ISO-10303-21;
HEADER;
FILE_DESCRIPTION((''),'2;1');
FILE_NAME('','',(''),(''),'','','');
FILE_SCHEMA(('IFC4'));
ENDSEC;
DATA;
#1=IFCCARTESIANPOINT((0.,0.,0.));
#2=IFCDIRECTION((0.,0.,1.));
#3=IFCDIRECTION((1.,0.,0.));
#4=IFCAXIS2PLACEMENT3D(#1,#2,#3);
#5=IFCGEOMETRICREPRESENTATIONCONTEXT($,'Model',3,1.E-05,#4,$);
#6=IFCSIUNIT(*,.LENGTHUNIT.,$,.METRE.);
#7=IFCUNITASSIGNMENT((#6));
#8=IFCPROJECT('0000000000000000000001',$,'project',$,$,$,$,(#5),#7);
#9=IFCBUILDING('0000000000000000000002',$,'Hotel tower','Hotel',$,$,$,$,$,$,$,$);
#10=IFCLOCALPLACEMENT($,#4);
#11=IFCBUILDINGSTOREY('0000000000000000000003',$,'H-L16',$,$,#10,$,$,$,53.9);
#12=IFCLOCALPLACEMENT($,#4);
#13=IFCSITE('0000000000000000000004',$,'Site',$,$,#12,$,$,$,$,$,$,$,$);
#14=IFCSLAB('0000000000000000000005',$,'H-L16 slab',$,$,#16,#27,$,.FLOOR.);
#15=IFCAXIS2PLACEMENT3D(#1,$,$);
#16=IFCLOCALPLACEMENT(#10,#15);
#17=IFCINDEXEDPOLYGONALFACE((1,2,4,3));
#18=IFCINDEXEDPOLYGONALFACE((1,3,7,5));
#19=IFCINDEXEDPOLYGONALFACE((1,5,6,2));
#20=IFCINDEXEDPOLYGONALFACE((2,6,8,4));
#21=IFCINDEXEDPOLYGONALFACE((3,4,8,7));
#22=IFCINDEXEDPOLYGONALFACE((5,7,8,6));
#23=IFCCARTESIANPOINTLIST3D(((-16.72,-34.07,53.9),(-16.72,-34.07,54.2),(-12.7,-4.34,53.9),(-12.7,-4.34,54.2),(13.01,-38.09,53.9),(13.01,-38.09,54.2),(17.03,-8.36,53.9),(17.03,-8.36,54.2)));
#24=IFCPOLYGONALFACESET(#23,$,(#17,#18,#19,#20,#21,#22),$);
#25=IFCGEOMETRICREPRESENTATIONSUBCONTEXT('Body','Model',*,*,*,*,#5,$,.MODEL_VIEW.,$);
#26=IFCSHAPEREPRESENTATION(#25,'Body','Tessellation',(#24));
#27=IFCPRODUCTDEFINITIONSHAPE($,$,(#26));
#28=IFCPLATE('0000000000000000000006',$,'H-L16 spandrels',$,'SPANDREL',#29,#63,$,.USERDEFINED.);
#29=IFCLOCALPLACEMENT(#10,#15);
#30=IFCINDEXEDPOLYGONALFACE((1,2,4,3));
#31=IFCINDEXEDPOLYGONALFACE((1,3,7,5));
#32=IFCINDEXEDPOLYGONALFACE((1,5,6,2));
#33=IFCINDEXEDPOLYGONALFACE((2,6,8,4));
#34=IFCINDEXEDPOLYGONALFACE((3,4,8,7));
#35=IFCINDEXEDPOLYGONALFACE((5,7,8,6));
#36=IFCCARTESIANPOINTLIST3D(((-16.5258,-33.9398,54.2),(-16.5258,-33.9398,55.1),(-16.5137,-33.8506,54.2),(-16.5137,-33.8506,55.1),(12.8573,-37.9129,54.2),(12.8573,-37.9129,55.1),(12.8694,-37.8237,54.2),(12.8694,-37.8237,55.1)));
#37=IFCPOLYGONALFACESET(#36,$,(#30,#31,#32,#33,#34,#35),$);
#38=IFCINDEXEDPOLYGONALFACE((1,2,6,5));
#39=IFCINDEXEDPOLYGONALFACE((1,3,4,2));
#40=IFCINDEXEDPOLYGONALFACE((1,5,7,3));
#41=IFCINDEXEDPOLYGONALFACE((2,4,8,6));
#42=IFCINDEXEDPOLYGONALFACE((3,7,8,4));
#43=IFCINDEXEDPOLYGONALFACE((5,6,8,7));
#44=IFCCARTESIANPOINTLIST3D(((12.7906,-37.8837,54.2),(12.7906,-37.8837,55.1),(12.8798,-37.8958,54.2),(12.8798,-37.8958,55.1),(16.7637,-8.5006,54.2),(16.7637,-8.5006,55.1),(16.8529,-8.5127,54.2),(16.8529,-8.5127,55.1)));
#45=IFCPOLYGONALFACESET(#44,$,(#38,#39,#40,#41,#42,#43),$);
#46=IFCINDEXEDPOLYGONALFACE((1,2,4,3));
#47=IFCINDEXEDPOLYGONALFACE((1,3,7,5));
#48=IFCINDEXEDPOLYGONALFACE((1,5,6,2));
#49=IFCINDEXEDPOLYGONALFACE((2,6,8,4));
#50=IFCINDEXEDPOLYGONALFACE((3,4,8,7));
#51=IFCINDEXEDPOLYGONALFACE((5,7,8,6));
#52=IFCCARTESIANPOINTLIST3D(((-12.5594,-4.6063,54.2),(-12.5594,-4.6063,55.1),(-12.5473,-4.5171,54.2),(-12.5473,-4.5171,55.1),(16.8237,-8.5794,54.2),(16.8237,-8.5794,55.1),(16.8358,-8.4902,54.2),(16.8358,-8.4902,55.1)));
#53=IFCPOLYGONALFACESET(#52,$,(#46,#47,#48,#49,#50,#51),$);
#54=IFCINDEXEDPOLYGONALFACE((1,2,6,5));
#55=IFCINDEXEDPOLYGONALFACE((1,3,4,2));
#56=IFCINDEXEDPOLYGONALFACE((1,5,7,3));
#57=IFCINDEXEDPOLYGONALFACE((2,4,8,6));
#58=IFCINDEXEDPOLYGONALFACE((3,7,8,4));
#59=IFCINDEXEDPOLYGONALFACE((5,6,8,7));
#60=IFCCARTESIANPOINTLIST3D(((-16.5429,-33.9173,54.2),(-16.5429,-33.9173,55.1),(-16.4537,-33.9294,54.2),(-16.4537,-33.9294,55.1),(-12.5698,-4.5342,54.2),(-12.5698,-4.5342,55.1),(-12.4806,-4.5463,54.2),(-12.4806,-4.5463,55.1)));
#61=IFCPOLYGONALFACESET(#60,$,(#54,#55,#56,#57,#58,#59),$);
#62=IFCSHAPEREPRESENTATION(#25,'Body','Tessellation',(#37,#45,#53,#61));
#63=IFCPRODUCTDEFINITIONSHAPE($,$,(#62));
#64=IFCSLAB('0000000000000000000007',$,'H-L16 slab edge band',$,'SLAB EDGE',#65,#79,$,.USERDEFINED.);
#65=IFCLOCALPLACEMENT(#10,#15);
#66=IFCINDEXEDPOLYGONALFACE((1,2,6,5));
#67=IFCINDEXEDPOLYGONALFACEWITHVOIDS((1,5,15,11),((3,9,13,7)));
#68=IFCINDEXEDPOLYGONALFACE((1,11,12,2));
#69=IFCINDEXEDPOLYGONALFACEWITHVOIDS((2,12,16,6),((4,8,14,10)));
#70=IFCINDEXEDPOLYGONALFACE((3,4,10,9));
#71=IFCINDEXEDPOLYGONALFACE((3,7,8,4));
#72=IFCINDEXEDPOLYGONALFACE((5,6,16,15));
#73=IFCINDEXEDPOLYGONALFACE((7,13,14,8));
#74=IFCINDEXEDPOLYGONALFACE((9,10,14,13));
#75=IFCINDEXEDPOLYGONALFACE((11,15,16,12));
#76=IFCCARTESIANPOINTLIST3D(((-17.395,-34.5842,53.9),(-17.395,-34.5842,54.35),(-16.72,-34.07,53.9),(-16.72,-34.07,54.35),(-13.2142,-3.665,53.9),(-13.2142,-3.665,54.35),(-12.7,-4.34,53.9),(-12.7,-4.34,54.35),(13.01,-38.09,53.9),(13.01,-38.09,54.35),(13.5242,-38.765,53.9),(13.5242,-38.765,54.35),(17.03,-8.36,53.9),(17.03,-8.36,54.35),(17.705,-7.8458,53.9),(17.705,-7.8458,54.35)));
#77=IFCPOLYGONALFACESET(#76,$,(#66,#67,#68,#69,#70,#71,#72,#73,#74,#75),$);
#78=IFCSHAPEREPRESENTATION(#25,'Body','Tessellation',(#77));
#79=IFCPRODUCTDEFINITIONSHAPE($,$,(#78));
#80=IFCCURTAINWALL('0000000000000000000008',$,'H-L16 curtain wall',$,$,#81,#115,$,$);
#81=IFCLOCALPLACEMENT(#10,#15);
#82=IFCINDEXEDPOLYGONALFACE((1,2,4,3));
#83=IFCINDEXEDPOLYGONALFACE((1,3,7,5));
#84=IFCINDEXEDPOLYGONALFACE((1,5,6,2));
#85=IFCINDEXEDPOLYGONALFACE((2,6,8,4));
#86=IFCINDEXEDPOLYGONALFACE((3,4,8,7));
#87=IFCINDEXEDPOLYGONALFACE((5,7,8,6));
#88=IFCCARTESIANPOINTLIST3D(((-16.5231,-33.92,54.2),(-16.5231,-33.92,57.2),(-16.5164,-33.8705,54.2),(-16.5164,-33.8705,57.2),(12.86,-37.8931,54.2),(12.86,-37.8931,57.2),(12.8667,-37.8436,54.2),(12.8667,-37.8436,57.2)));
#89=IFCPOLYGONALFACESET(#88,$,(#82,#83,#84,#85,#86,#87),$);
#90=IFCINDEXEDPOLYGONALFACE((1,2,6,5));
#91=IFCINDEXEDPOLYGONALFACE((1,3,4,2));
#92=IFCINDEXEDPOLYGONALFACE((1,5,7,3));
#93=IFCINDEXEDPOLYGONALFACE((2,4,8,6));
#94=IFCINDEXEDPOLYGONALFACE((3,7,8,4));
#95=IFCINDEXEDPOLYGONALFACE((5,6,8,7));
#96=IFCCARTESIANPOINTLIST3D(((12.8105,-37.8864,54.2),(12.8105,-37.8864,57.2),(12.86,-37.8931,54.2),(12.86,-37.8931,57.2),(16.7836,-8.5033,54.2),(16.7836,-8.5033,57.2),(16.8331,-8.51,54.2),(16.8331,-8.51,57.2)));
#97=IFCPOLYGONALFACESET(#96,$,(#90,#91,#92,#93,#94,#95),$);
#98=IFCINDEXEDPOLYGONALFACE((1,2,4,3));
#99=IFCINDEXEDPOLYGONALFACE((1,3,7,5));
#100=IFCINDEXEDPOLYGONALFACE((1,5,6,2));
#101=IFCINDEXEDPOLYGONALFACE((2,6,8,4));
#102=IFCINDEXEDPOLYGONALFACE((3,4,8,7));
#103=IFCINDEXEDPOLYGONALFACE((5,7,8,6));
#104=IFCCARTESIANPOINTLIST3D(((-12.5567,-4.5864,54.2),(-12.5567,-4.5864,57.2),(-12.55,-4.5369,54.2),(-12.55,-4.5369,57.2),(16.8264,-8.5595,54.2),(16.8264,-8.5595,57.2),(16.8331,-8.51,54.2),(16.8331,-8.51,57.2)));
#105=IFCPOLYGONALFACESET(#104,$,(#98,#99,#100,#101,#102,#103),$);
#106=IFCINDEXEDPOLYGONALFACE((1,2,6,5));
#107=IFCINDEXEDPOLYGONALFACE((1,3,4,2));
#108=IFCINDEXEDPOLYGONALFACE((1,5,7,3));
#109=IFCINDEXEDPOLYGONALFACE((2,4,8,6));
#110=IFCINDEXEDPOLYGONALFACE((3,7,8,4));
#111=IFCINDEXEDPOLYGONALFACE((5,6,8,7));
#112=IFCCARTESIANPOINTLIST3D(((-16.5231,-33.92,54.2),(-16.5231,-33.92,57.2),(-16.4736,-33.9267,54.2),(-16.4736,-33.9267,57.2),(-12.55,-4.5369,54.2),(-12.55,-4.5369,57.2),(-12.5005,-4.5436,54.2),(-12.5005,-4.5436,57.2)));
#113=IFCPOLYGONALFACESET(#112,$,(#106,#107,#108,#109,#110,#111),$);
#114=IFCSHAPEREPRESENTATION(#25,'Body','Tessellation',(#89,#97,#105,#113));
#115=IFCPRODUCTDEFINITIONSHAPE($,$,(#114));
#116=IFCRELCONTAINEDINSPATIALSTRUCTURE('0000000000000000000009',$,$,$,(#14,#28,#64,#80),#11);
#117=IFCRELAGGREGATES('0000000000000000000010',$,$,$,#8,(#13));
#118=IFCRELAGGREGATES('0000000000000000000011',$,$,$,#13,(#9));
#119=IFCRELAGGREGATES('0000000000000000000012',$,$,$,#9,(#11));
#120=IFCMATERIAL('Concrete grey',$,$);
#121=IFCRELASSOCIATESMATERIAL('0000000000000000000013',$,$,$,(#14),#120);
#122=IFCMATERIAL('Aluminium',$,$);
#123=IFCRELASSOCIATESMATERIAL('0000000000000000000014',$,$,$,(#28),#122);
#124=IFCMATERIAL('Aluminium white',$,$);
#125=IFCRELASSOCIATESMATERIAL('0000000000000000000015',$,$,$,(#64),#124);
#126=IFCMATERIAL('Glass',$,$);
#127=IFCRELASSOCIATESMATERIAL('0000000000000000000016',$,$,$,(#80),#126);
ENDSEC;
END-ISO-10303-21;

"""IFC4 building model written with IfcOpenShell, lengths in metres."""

from ifc_helpers import new_model, si_unit, frame, origin_with_axes, place, context, subcontext, project, spatial, polyline, outline, extrude, material, element, save


model = new_model("IFC4")

# Units and contexts
model_context = context("Model", 3, precision=1e-05, world=origin_with_axes())
body_context = subcontext(model_context, "Body", "Model", "MODEL_VIEW")
ifc_project = project(units=[si_unit("LENGTHUNIT", "METRE")], contexts=[model_context])

# Site, building, storey
site_placement = place(None, origin_with_axes())
site = spatial("IfcSite", under=ifc_project, at=site_placement, Name="Site")
building = spatial("IfcBuilding", under=site, Name="Hotel tower", Description="Hotel")
storey_placement = place(None, origin_with_axes())
storey = spatial("IfcBuildingStorey", under=building, at=storey_placement, Name="H-L16", Elevation=53.9)

# Shared definitions
ifc_material_1 = material(Name="Aluminium")

# Slab
ifc_material_2 = material(Name="Concrete grey")
slab_1_placement = place(storey_placement, origin_with_axes())
element("IfcSlab", 1, at=slab_1_placement, inside=storey, material=ifc_material_2, Name="H-L16 slab", PredefinedType="FLOOR", context=body_context, shape_type="SweptSolid", body=[
    extrude(outline(polyline([(-16.72, -34.07), (13.01, -38.09), (17.03, -8.36), (-12.7, -4.34), (-16.72, -34.07)])), frame((0.0, 0.0, 53.9), z_axis=(0.0, 0.0, 1.0), x_axis=(1.0, 0.0, 0.0)), (0.0, 0.0, 1.0), 0.3),
])

# Plate
plate_placement = place(storey_placement, origin_with_axes())
element("IfcPlate", 2, at=plate_placement, inside=storey, material=ifc_material_1, Name="H-L16 spandrels", ObjectType="SPANDREL", PredefinedType="USERDEFINED", context=body_context, shape_type="SweptSolid", body=[
    extrude(outline(polyline([(-16.5258, -33.9398), (12.8573, -37.9129), (12.8694, -37.8237), (-16.5137, -33.8506), (-16.5258, -33.9398)])), frame((0.0, 0.0, 54.2), z_axis=(0.0, 0.0, 1.0), x_axis=(1.0, 0.0, 0.0)), (0.0, 0.0, 1.0), 0.9),
    extrude(outline(polyline([(12.8798, -37.8958), (16.8529, -8.5127), (16.7637, -8.5006), (12.7906, -37.8837), (12.8798, -37.8958)])), frame((0.0, 0.0, 54.2), z_axis=(0.0, 0.0, 1.0), x_axis=(1.0, 0.0, 0.0)), (0.0, 0.0, 1.0), 0.9),
    extrude(outline(polyline([(16.8358, -8.4902), (-12.5473, -4.5171), (-12.5594, -4.6063), (16.8237, -8.5794), (16.8358, -8.4902)])), frame((0.0, 0.0, 54.2), z_axis=(0.0, 0.0, 1.0), x_axis=(1.0, 0.0, 0.0)), (0.0, 0.0, 1.0), 0.9),
    extrude(outline(polyline([(-12.5698, -4.5342), (-16.5429, -33.9173), (-16.4537, -33.9294), (-12.4806, -4.5463), (-12.5698, -4.5342)])), frame((0.0, 0.0, 54.2), z_axis=(0.0, 0.0, 1.0), x_axis=(1.0, 0.0, 0.0)), (0.0, 0.0, 1.0), 0.9),
])

# Slab
ifc_material_3 = material(Name="Aluminium white")
slab_2_placement = place(storey_placement, origin_with_axes())
element("IfcSlab", 3, at=slab_2_placement, inside=storey, material=ifc_material_3, Name="H-L16 slab edge band", ObjectType="SLAB EDGE", PredefinedType="USERDEFINED", context=body_context, shape_type="SweptSolid", body=[
    extrude(outline(polyline([(-17.395, -34.5842), (13.5242, -38.765), (17.705, -7.8458), (-13.2142, -3.665), (-17.395, -34.5842)]), holes=[polyline([(-16.72, -34.07), (13.01, -38.09), (17.03, -8.36), (-12.7, -4.34), (-16.72, -34.07)])]), frame((0.0, 0.0, 53.9), z_axis=(0.0, 0.0, 1.0), x_axis=(1.0, 0.0, 0.0)), (0.0, 0.0, 1.0), 0.45),
])

# Curtain wall
ifc_material_4 = material(Name="Glass")
curtain_wall_placement = place(storey_placement, origin_with_axes())
element("IfcCurtainWall", 4, at=curtain_wall_placement, inside=storey, material=ifc_material_4, Name="H-L16 curtain wall", context=body_context, shape_type="SweptSolid", body=[
    extrude(outline(polyline([(-16.5231, -33.92), (12.86, -37.8931), (12.8667, -37.8436), (-16.5164, -33.8705), (-16.5231, -33.92)])), frame((0.0, 0.0, 54.2), z_axis=(0.0, 0.0, 1.0), x_axis=(1.0, 0.0, 0.0)), (0.0, 0.0, 1.0), 3.0),
    extrude(outline(polyline([(12.86, -37.8931), (16.8331, -8.51), (16.7836, -8.5033), (12.8105, -37.8864), (12.86, -37.8931)])), frame((0.0, 0.0, 54.2), z_axis=(0.0, 0.0, 1.0), x_axis=(1.0, 0.0, 0.0)), (0.0, 0.0, 1.0), 3.0),
    extrude(outline(polyline([(16.8331, -8.51), (-12.55, -4.5369), (-12.5567, -4.5864), (16.8264, -8.5595), (16.8331, -8.51)])), frame((0.0, 0.0, 54.2), z_axis=(0.0, 0.0, 1.0), x_axis=(1.0, 0.0, 0.0)), (0.0, 0.0, 1.0), 3.0),
    extrude(outline(polyline([(-12.55, -4.5369), (-16.5231, -33.92), (-16.4736, -33.9267), (-12.5005, -4.5436), (-12.55, -4.5369)])), frame((0.0, 0.0, 54.2), z_axis=(0.0, 0.0, 1.0), x_axis=(1.0, 0.0, 0.0)), (0.0, 0.0, 1.0), 3.0),
])

save(model, "model.ifc")
